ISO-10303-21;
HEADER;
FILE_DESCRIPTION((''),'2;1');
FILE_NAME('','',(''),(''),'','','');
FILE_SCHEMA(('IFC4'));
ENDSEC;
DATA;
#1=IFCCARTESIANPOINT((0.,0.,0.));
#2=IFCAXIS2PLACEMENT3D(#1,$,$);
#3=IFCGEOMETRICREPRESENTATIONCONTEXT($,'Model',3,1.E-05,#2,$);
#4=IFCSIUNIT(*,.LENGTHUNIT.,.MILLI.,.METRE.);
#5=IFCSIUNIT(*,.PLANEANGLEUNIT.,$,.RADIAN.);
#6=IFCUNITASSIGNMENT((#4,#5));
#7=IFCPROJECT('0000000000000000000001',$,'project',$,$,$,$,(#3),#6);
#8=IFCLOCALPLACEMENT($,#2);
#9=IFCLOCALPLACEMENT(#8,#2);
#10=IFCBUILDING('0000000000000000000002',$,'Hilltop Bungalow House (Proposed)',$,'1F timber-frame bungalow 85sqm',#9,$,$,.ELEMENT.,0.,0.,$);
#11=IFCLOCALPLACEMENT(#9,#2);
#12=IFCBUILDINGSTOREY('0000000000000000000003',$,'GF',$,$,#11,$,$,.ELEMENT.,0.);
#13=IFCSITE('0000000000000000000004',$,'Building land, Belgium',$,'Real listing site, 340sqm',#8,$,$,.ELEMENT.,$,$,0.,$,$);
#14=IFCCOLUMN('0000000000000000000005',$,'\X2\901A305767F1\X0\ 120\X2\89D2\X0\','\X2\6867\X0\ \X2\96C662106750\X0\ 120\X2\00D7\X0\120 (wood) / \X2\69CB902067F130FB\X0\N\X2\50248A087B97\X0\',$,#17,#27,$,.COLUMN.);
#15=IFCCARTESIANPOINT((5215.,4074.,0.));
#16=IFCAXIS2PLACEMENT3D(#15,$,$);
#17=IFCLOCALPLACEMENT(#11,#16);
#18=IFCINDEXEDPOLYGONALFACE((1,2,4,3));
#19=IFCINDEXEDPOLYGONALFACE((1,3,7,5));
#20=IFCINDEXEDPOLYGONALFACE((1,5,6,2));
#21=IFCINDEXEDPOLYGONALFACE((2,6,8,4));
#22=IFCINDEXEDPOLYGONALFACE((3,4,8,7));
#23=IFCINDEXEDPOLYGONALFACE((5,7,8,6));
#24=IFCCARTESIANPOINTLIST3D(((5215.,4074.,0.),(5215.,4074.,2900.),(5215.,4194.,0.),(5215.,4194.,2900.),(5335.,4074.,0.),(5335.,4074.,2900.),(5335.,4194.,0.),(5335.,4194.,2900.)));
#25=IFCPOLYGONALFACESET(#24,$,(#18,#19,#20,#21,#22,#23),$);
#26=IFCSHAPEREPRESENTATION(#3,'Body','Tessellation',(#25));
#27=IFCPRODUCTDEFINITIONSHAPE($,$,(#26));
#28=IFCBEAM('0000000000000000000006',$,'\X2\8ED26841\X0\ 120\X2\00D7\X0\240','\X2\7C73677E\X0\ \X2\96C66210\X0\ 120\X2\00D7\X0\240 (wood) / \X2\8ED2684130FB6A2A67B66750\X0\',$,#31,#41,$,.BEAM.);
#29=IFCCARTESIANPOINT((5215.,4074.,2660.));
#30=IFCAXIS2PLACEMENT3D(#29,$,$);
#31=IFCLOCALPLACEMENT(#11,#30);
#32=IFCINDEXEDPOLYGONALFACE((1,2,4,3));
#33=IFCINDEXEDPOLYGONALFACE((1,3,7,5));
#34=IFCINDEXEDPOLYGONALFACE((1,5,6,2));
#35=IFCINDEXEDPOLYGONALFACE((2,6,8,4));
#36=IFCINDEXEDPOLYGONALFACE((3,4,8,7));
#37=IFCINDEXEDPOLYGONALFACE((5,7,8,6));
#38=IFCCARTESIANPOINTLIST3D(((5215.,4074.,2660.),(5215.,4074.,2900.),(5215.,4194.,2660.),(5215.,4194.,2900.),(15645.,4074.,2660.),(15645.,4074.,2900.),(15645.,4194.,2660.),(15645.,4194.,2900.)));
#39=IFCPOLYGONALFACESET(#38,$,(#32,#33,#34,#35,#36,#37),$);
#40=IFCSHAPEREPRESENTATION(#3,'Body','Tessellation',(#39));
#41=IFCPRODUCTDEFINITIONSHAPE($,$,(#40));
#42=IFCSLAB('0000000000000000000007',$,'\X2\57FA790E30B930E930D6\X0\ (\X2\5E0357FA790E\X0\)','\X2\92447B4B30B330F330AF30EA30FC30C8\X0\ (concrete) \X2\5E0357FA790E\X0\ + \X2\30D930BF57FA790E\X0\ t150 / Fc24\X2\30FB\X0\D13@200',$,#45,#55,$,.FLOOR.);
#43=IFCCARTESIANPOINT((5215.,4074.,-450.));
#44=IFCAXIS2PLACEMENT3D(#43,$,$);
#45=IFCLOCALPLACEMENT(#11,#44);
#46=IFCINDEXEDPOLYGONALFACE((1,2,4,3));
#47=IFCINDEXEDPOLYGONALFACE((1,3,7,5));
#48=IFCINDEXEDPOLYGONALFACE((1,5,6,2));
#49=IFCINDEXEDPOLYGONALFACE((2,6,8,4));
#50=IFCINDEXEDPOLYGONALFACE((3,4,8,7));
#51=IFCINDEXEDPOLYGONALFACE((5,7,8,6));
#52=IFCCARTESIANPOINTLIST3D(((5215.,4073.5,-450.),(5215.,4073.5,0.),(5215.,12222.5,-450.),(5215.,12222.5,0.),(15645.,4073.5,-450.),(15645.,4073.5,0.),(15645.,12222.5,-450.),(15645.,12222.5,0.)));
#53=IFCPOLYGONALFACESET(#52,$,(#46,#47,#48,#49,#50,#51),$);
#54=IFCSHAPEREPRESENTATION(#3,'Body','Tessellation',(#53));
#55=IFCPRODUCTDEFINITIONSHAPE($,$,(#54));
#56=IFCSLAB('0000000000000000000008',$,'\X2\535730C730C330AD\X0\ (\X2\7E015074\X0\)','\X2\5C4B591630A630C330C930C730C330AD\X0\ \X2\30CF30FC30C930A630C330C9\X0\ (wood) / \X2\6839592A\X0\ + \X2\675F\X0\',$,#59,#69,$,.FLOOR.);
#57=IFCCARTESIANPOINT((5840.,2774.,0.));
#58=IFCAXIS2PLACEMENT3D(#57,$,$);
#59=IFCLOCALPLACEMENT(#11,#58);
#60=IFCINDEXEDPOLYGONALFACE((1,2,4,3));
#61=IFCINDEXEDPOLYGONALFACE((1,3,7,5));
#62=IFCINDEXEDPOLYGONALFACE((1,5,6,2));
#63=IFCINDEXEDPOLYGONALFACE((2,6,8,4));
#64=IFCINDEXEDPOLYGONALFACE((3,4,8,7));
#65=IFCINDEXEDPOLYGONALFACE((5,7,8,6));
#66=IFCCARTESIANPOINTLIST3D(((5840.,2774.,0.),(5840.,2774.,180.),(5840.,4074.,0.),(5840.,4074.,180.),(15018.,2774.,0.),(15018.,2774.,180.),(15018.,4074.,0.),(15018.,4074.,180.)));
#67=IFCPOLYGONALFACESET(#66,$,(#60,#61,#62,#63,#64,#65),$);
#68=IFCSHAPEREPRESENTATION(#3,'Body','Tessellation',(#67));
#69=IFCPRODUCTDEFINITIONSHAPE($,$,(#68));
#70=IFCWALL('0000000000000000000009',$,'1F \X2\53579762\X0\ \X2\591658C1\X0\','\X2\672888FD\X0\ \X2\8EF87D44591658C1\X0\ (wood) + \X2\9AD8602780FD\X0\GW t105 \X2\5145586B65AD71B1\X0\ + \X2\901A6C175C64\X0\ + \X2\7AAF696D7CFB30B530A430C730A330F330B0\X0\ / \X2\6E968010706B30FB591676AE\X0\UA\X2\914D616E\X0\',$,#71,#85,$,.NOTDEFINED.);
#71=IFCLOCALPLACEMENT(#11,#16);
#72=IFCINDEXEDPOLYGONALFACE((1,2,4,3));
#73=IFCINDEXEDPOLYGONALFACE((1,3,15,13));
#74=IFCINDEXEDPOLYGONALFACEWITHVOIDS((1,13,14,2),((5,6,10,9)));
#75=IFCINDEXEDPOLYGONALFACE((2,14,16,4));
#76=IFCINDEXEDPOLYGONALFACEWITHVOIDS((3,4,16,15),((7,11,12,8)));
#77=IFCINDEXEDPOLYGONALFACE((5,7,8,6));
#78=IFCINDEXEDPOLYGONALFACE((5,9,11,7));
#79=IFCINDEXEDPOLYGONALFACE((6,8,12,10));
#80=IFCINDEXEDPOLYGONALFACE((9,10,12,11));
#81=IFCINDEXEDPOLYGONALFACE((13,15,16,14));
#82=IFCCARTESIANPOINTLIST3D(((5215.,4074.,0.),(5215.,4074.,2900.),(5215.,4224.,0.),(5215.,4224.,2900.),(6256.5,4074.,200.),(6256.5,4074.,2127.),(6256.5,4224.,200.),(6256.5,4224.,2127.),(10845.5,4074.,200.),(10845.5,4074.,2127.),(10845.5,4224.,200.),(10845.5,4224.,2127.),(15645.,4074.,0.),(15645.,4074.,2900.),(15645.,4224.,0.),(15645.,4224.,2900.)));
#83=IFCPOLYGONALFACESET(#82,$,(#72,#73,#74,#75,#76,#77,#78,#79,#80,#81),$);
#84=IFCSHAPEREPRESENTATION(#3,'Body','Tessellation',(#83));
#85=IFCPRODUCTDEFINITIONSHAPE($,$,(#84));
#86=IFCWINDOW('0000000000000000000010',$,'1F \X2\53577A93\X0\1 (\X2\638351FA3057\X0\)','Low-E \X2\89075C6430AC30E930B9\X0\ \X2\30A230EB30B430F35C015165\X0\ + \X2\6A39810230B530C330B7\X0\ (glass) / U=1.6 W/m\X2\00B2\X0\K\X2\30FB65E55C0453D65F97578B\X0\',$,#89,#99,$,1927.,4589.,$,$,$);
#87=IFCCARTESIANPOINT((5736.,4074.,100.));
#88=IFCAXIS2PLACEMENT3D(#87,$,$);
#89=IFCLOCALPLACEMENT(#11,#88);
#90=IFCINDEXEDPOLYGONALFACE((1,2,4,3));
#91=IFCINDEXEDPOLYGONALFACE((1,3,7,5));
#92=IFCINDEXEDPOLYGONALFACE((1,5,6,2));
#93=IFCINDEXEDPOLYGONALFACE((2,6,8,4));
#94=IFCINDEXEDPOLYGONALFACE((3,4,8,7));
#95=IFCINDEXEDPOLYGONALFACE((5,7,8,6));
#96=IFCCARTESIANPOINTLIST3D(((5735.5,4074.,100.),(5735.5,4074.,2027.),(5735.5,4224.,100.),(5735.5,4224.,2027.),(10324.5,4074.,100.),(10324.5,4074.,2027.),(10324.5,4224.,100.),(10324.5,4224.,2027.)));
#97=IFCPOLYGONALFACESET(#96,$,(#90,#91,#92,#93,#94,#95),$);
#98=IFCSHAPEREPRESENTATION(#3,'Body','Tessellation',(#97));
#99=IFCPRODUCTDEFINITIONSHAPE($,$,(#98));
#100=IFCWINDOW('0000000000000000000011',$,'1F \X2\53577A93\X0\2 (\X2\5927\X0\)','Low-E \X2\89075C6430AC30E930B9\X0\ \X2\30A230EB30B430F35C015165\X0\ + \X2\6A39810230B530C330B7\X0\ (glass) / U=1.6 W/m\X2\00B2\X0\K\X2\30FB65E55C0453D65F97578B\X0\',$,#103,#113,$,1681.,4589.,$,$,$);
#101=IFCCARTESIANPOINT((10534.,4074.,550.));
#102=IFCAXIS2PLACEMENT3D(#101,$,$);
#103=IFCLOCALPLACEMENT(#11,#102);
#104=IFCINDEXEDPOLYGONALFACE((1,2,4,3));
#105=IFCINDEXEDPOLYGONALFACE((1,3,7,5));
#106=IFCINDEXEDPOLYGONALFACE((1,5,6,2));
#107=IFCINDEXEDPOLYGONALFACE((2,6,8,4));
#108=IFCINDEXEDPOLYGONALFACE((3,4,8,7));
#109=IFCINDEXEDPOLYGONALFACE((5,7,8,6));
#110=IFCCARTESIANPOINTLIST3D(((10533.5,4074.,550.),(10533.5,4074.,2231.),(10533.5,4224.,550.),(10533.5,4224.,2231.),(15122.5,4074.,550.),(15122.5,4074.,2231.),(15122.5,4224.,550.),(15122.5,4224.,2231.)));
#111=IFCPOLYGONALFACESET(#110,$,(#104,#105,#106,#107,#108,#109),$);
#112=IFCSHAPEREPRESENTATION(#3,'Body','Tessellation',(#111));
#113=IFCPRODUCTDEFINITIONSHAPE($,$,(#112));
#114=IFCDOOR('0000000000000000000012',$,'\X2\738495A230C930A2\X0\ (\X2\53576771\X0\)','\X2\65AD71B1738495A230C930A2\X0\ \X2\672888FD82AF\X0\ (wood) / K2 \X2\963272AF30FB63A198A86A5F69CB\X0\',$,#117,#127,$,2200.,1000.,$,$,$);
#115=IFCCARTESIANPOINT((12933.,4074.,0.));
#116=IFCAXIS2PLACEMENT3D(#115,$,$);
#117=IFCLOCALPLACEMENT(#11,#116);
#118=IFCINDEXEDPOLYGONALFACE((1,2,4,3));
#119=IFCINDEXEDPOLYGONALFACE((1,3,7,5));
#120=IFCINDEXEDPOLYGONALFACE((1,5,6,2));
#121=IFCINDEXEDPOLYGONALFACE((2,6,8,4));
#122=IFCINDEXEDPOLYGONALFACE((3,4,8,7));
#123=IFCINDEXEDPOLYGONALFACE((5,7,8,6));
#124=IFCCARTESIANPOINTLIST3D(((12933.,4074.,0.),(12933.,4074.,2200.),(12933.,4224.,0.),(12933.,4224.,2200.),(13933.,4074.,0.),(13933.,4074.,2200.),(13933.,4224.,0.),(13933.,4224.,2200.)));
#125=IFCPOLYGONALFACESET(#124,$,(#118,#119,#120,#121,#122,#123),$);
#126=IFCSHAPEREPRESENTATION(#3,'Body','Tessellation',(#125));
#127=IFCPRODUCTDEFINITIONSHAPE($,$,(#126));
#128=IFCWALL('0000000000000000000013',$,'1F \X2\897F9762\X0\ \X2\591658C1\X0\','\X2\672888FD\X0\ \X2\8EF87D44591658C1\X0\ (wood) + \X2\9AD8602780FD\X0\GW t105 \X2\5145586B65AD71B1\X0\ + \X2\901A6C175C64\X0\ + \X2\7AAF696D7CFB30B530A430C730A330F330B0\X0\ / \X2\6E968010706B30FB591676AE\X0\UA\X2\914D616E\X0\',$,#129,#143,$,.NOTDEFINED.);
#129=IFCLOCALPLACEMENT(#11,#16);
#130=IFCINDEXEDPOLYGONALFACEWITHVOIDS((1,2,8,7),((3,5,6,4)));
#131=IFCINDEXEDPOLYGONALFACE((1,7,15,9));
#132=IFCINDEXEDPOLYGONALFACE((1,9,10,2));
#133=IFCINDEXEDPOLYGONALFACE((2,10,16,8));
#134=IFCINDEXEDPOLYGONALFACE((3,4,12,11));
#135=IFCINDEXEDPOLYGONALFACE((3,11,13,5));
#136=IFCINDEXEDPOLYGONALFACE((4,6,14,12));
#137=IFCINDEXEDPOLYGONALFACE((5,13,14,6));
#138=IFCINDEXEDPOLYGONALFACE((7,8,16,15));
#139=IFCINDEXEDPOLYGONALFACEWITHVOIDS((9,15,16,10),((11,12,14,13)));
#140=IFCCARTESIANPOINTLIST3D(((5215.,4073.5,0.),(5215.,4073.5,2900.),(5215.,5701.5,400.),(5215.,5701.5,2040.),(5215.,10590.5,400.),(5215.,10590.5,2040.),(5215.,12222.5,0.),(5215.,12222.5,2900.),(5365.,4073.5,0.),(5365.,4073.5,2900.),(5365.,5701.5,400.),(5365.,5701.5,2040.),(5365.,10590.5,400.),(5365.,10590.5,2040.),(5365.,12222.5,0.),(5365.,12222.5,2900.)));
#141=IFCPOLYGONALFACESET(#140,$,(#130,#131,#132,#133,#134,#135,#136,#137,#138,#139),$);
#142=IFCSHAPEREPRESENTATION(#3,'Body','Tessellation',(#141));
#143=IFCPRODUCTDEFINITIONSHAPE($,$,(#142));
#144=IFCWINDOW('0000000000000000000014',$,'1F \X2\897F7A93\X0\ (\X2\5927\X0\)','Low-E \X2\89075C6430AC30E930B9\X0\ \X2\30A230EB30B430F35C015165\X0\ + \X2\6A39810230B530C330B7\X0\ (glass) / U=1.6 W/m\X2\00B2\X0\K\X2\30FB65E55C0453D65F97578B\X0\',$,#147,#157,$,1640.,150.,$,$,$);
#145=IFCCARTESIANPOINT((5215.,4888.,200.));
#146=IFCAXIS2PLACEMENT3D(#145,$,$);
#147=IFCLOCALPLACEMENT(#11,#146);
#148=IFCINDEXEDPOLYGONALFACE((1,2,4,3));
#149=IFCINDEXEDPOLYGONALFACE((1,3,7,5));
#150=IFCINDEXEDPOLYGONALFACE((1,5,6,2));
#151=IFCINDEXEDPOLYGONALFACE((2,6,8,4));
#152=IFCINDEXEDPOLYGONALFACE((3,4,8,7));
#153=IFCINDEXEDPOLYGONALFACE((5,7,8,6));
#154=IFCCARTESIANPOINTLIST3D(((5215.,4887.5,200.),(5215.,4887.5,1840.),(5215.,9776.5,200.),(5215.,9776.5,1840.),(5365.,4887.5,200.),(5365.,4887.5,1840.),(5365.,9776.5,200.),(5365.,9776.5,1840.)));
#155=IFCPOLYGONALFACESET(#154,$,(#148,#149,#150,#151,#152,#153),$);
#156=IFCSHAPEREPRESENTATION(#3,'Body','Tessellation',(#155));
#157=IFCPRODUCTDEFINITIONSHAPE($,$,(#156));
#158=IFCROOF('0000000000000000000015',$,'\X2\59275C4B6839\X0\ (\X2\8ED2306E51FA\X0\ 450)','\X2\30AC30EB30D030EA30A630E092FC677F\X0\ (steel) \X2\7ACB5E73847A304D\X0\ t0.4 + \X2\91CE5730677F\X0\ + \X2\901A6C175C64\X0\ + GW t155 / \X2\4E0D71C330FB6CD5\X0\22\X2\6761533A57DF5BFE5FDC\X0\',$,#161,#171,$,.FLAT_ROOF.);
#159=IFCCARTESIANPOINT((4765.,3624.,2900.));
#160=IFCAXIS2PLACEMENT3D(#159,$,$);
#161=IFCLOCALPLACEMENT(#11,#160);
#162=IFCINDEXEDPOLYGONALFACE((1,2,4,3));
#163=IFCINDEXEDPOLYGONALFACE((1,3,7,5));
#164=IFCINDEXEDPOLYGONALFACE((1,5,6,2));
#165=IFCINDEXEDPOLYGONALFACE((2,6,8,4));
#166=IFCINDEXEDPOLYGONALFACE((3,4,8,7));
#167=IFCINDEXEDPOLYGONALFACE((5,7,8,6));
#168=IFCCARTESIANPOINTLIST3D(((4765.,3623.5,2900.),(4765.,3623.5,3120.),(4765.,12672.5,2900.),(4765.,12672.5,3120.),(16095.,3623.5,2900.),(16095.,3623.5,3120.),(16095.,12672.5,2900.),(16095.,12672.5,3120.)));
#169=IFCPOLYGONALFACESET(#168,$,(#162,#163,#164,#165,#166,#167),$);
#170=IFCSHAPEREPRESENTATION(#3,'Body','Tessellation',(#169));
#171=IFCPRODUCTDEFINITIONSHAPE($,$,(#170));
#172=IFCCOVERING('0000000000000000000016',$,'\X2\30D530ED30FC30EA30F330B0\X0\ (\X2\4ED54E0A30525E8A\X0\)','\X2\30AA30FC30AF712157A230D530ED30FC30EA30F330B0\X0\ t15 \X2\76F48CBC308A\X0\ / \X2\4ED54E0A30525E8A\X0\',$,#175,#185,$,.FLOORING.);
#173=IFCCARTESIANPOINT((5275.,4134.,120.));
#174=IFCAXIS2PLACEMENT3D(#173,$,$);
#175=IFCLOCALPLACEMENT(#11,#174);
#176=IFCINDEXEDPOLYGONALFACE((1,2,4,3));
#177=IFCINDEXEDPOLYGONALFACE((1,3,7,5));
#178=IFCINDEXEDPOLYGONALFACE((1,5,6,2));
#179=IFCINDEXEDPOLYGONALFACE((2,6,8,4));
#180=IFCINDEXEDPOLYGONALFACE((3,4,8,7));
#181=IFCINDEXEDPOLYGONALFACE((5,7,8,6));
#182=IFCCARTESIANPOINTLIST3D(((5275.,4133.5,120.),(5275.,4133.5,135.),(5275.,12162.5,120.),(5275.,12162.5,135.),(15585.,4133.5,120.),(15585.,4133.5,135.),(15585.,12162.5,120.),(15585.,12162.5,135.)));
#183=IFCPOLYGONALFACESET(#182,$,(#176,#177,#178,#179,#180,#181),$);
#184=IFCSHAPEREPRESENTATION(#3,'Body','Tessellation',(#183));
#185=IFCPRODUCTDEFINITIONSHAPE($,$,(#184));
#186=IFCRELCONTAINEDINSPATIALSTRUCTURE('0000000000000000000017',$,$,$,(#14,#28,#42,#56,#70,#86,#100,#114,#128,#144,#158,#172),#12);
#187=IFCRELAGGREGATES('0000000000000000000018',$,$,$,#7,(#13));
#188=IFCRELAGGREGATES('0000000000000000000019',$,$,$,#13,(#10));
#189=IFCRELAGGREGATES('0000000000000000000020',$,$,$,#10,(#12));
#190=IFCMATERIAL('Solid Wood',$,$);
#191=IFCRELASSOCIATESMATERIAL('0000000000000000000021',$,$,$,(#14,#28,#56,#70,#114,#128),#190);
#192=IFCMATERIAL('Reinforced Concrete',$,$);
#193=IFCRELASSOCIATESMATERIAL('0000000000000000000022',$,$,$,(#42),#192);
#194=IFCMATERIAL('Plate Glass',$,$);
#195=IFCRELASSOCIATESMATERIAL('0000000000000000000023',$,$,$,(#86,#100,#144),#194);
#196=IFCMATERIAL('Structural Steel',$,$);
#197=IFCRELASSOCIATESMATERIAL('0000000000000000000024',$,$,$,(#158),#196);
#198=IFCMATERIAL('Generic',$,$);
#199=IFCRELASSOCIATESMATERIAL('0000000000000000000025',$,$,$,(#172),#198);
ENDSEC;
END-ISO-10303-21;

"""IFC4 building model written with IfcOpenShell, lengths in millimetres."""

from ifc_helpers import new_model, si_unit, frame, frame_2d, origin, place, context, project, spatial, rectangle, extrude, material, element, fill, save


model = new_model("IFC4")

# Units and contexts
model_context = context("Model", 3, precision=1e-05, world=origin())
ifc_project = project(units=[si_unit("LENGTHUNIT", "METRE", prefix="MILLI"), si_unit("PLANEANGLEUNIT", "RADIAN")], contexts=[model_context])

# Site, building, storey
site_placement = place(None, origin())
site = spatial("IfcSite", under=ifc_project, at=site_placement, Name="Building land, Belgium", ObjectType="Real listing site, 340sqm", CompositionType="ELEMENT", RefElevation=0.0)
building_placement = place(site_placement, origin())
building = spatial("IfcBuilding", under=site, at=building_placement, Name="Hilltop Bungalow House (Proposed)", ObjectType="1F timber-frame bungalow 85sqm", CompositionType="ELEMENT", ElevationOfRefHeight=0.0, ElevationOfTerrain=0.0)
storey_placement = place(building_placement, origin())
storey = spatial("IfcBuildingStorey", under=building, at=storey_placement, Name="GF", CompositionType="ELEMENT", Elevation=0.0)

# Column
ifc_material_1 = material(Name="Solid Wood")
column_1_placement = place(storey_placement, frame((5215.0, 4074.0, 0.0)))
element("IfcColumn", 1, at=column_1_placement, inside=storey, material=ifc_material_1, Name="通し柱 120角", Description="桧 集成材 120×120 (wood) / 構造柱・N値計算", PredefinedType="COLUMN", context=model_context, shape_type="SweptSolid", body=[
    extrude(rectangle(XDim=120.0, YDim=120.0, at=frame_2d((60.0, 60.0))), frame((5215.0, 4074.0, 0.0)), (0.0, 0.0, 1.0), 2900.0),
])

# Beam
beam_1_placement = place(storey_placement, frame((5215.0, 4074.0, 2660.0)))
element("IfcBeam", 2, at=beam_1_placement, inside=storey, material=ifc_material_1, Name="軒桁 120×240", Description="米松 集成 120×240 (wood) / 軒桁・横架材", PredefinedType="BEAM", context=model_context, shape_type="SweptSolid", body=[
    extrude(rectangle(XDim=10430.0, YDim=120.0, at=frame_2d((5215.0, 60.0))), frame((5215.0, 4074.0, 2660.0)), (0.0, 0.0, 1.0), 240.0),
])

# Slabs
ifc_material_2 = material(Name="Reinforced Concrete")
slab_1_placement = place(storey_placement, frame((5215.0, 4074.0, -450.0)))
element("IfcSlab", 3, at=slab_1_placement, inside=storey, material=ifc_material_2, Name="基礎スラブ (布基礎)", Description="鉄筋コンクリート (concrete) 布基礎 + ベタ基礎 t150 / Fc24・D13@200", PredefinedType="FLOOR", context=model_context, shape_type="SweptSolid", body=[
    extrude(rectangle(XDim=10430.0, YDim=8149.0, at=frame_2d((5215.0, 4074.0))), frame((5215.0, 4074.0, -450.0)), (0.0, 0.0, 1.0), 450.0),
])
slab_2_placement = place(storey_placement, frame((5840.0, 2774.0, 0.0)))
element("IfcSlab", 4, at=slab_2_placement, inside=storey, material=ifc_material_1, Name="南デッキ (縁側)", Description="屋外ウッドデッキ ハードウッド (wood) / 根太 + 束", PredefinedType="FLOOR", context=model_context, shape_type="SweptSolid", body=[
    extrude(rectangle(XDim=9178.0, YDim=1300.0, at=frame_2d((4589.0, 650.0))), frame((5840.0, 2774.0, 0.0)), (0.0, 0.0, 1.0), 180.0),
])

# Wall, openings, windows, door
wall_1_placement = place(storey_placement, frame((5215.0, 4074.0, 0.0)))
wall_1 = element("IfcWall", 5, at=wall_1_placement, inside=storey, material=ifc_material_1, Name="1F 南面 外壁", Description="木製 軸組外壁 (wood) + 高性能GW t105 充填断熱 + 通気層 + 窯業系サイディング / 準耐火・外皮UA配慮", PredefinedType="NOTDEFINED", context=model_context, shape_type="SweptSolid", body=[
    extrude(rectangle(XDim=10430.0, YDim=150.0, at=frame_2d((5215.0, 75.0))), frame((5215.0, 4074.0, 0.0)), (0.0, 0.0, 1.0), 2900.0),
])
opening_1_placement = place(storey_placement, frame((5736.0, 4074.0, 100.0)))
opening_1 = element("IfcOpeningElement", 6, at=opening_1_placement, cuts=wall_1, PredefinedType="NOTDEFINED", context=model_context, shape_type="SweptSolid", body=[
    extrude(rectangle(XDim=4589.0, YDim=150.0, at=frame_2d((2294.0, 75.0))), frame((5736.0, 4074.0, 100.0)), (0.0, 0.0, 1.0), 1927.0),
])
opening_2_placement = place(storey_placement, frame((10534.0, 4074.0, 550.0)))
opening_2 = element("IfcOpeningElement", 7, at=opening_2_placement, cuts=wall_1, PredefinedType="NOTDEFINED", context=model_context, shape_type="SweptSolid", body=[
    extrude(rectangle(XDim=4589.0, YDim=150.0, at=frame_2d((2294.0, 75.0))), frame((10534.0, 4074.0, 550.0)), (0.0, 0.0, 1.0), 1681.0),
])
opening_3_placement = place(storey_placement, frame((12933.0, 4074.0, 0.0)))
opening_3 = element("IfcOpeningElement", 8, at=opening_3_placement, cuts=wall_1, PredefinedType="NOTDEFINED", context=model_context, shape_type="SweptSolid", body=[
    extrude(rectangle(XDim=1000.0, YDim=150.0, at=frame_2d((500.0, 75.0))), frame((12933.0, 4074.0, 0.0)), (0.0, 0.0, 1.0), 2200.0),
])
ifc_material_3 = material(Name="Plate Glass")
window_1_placement = place(storey_placement, frame((5736.0, 4074.0, 100.0)))
window_1 = element("IfcWindow", 9, at=window_1_placement, inside=storey, material=ifc_material_3, Name="1F 南窓1 (掃出し)", Description="Low-E 複層ガラス アルゴン封入 + 樹脂サッシ (glass) / U=1.6 W/m²K・日射取得型", OverallHeight=1927.0, OverallWidth=4589.0, context=model_context, shape_type="SweptSolid", body=[
    extrude(rectangle(XDim=4589.0, YDim=150.0, at=frame_2d((2294.0, 75.0))), frame((5736.0, 4074.0, 100.0)), (0.0, 0.0, 1.0), 1927.0),
])
fill(opening_1, window_1)
window_2_placement = place(storey_placement, frame((10534.0, 4074.0, 550.0)))
window_2 = element("IfcWindow", 10, at=window_2_placement, inside=storey, material=ifc_material_3, Name="1F 南窓2 (大)", Description="Low-E 複層ガラス アルゴン封入 + 樹脂サッシ (glass) / U=1.6 W/m²K・日射取得型", OverallHeight=1681.0, OverallWidth=4589.0, context=model_context, shape_type="SweptSolid", body=[
    extrude(rectangle(XDim=4589.0, YDim=150.0, at=frame_2d((2294.0, 75.0))), frame((10534.0, 4074.0, 550.0)), (0.0, 0.0, 1.0), 1681.0),
])
fill(opening_2, window_2)
door_placement = place(storey_placement, frame((12933.0, 4074.0, 0.0)))
door = element("IfcDoor", 11, at=door_placement, inside=storey, material=ifc_material_1, Name="玄関ドア (南東)", Description="断熱玄関ドア 木製芯 (wood) / K2 防犯・採風機構", OverallHeight=2200.0, OverallWidth=1000.0, context=model_context, shape_type="SweptSolid", body=[
    extrude(rectangle(XDim=1000.0, YDim=150.0, at=frame_2d((500.0, 75.0))), frame((12933.0, 4074.0, 0.0)), (0.0, 0.0, 1.0), 2200.0),
])
fill(opening_3, door)

# Wall, opening, window
wall_2_placement = place(storey_placement, frame((5215.0, 4074.0, 0.0)))
wall_2 = element("IfcWall", 12, at=wall_2_placement, inside=storey, material=ifc_material_1, Name="1F 西面 外壁", Description="木製 軸組外壁 (wood) + 高性能GW t105 充填断熱 + 通気層 + 窯業系サイディング / 準耐火・外皮UA配慮", PredefinedType="NOTDEFINED", context=model_context, shape_type="SweptSolid", body=[
    extrude(rectangle(XDim=150.0, YDim=8149.0, at=frame_2d((75.0, 4074.0))), frame((5215.0, 4074.0, 0.0)), (0.0, 0.0, 1.0), 2900.0),
])
opening_4_placement = place(storey_placement, frame((5215.0, 4888.0, 200.0)))
opening_4 = element("IfcOpeningElement", 13, at=opening_4_placement, cuts=wall_2, PredefinedType="NOTDEFINED", context=model_context, shape_type="SweptSolid", body=[
    extrude(rectangle(XDim=150.0, YDim=4889.0, at=frame_2d((75.0, 2444.0))), frame((5215.0, 4888.0, 200.0)), (0.0, 0.0, 1.0), 1640.0),
])
window_3_placement = place(storey_placement, frame((5215.0, 4888.0, 200.0)))
window_3 = element("IfcWindow", 14, at=window_3_placement, inside=storey, material=ifc_material_3, Name="1F 西窓 (大)", Description="Low-E 複層ガラス アルゴン封入 + 樹脂サッシ (glass) / U=1.6 W/m²K・日射取得型", OverallHeight=1640.0, OverallWidth=150.0, context=model_context, shape_type="SweptSolid", body=[
    extrude(rectangle(XDim=150.0, YDim=4889.0, at=frame_2d((75.0, 2444.0))), frame((5215.0, 4888.0, 200.0)), (0.0, 0.0, 1.0), 1640.0),
])
fill(opening_4, window_3)

# Roof
ifc_material_4 = material(Name="Structural Steel")
roof_placement = place(storey_placement, frame((4765.0, 3624.0, 2900.0)))
element("IfcRoof", 15, at=roof_placement, inside=storey, material=ifc_material_4, Name="大屋根 (軒の出 450)", Description="ガルバリウム鋼板 (steel) 立平葺き t0.4 + 野地板 + 通気層 + GW t155 / 不燃・法22条区域対応", PredefinedType="FLAT_ROOF", context=model_context, shape_type="SweptSolid", body=[
    extrude(rectangle(XDim=11330.0, YDim=9049.0, at=frame_2d((5665.0, 4524.0))), frame((4765.0, 3624.0, 2900.0)), (0.0, 0.0, 1.0), 220.0),
])

# Covering
ifc_material_5 = material(Name="Generic")
covering_1_placement = place(storey_placement, frame((5275.0, 4134.0, 120.0)))
element("IfcCovering", 16, at=covering_1_placement, inside=storey, material=ifc_material_5, Name="フローリング (仕上げ床)", Description="オーク無垢フローリング t15 直貼り / 仕上げ床", PredefinedType="FLOORING", context=model_context, shape_type="SweptSolid", body=[
    extrude(rectangle(XDim=10310.0, YDim=8029.0, at=frame_2d((5155.0, 4014.0))), frame((5275.0, 4134.0, 120.0)), (0.0, 0.0, 1.0), 15.0),
])

save(model, "model.ifc")
